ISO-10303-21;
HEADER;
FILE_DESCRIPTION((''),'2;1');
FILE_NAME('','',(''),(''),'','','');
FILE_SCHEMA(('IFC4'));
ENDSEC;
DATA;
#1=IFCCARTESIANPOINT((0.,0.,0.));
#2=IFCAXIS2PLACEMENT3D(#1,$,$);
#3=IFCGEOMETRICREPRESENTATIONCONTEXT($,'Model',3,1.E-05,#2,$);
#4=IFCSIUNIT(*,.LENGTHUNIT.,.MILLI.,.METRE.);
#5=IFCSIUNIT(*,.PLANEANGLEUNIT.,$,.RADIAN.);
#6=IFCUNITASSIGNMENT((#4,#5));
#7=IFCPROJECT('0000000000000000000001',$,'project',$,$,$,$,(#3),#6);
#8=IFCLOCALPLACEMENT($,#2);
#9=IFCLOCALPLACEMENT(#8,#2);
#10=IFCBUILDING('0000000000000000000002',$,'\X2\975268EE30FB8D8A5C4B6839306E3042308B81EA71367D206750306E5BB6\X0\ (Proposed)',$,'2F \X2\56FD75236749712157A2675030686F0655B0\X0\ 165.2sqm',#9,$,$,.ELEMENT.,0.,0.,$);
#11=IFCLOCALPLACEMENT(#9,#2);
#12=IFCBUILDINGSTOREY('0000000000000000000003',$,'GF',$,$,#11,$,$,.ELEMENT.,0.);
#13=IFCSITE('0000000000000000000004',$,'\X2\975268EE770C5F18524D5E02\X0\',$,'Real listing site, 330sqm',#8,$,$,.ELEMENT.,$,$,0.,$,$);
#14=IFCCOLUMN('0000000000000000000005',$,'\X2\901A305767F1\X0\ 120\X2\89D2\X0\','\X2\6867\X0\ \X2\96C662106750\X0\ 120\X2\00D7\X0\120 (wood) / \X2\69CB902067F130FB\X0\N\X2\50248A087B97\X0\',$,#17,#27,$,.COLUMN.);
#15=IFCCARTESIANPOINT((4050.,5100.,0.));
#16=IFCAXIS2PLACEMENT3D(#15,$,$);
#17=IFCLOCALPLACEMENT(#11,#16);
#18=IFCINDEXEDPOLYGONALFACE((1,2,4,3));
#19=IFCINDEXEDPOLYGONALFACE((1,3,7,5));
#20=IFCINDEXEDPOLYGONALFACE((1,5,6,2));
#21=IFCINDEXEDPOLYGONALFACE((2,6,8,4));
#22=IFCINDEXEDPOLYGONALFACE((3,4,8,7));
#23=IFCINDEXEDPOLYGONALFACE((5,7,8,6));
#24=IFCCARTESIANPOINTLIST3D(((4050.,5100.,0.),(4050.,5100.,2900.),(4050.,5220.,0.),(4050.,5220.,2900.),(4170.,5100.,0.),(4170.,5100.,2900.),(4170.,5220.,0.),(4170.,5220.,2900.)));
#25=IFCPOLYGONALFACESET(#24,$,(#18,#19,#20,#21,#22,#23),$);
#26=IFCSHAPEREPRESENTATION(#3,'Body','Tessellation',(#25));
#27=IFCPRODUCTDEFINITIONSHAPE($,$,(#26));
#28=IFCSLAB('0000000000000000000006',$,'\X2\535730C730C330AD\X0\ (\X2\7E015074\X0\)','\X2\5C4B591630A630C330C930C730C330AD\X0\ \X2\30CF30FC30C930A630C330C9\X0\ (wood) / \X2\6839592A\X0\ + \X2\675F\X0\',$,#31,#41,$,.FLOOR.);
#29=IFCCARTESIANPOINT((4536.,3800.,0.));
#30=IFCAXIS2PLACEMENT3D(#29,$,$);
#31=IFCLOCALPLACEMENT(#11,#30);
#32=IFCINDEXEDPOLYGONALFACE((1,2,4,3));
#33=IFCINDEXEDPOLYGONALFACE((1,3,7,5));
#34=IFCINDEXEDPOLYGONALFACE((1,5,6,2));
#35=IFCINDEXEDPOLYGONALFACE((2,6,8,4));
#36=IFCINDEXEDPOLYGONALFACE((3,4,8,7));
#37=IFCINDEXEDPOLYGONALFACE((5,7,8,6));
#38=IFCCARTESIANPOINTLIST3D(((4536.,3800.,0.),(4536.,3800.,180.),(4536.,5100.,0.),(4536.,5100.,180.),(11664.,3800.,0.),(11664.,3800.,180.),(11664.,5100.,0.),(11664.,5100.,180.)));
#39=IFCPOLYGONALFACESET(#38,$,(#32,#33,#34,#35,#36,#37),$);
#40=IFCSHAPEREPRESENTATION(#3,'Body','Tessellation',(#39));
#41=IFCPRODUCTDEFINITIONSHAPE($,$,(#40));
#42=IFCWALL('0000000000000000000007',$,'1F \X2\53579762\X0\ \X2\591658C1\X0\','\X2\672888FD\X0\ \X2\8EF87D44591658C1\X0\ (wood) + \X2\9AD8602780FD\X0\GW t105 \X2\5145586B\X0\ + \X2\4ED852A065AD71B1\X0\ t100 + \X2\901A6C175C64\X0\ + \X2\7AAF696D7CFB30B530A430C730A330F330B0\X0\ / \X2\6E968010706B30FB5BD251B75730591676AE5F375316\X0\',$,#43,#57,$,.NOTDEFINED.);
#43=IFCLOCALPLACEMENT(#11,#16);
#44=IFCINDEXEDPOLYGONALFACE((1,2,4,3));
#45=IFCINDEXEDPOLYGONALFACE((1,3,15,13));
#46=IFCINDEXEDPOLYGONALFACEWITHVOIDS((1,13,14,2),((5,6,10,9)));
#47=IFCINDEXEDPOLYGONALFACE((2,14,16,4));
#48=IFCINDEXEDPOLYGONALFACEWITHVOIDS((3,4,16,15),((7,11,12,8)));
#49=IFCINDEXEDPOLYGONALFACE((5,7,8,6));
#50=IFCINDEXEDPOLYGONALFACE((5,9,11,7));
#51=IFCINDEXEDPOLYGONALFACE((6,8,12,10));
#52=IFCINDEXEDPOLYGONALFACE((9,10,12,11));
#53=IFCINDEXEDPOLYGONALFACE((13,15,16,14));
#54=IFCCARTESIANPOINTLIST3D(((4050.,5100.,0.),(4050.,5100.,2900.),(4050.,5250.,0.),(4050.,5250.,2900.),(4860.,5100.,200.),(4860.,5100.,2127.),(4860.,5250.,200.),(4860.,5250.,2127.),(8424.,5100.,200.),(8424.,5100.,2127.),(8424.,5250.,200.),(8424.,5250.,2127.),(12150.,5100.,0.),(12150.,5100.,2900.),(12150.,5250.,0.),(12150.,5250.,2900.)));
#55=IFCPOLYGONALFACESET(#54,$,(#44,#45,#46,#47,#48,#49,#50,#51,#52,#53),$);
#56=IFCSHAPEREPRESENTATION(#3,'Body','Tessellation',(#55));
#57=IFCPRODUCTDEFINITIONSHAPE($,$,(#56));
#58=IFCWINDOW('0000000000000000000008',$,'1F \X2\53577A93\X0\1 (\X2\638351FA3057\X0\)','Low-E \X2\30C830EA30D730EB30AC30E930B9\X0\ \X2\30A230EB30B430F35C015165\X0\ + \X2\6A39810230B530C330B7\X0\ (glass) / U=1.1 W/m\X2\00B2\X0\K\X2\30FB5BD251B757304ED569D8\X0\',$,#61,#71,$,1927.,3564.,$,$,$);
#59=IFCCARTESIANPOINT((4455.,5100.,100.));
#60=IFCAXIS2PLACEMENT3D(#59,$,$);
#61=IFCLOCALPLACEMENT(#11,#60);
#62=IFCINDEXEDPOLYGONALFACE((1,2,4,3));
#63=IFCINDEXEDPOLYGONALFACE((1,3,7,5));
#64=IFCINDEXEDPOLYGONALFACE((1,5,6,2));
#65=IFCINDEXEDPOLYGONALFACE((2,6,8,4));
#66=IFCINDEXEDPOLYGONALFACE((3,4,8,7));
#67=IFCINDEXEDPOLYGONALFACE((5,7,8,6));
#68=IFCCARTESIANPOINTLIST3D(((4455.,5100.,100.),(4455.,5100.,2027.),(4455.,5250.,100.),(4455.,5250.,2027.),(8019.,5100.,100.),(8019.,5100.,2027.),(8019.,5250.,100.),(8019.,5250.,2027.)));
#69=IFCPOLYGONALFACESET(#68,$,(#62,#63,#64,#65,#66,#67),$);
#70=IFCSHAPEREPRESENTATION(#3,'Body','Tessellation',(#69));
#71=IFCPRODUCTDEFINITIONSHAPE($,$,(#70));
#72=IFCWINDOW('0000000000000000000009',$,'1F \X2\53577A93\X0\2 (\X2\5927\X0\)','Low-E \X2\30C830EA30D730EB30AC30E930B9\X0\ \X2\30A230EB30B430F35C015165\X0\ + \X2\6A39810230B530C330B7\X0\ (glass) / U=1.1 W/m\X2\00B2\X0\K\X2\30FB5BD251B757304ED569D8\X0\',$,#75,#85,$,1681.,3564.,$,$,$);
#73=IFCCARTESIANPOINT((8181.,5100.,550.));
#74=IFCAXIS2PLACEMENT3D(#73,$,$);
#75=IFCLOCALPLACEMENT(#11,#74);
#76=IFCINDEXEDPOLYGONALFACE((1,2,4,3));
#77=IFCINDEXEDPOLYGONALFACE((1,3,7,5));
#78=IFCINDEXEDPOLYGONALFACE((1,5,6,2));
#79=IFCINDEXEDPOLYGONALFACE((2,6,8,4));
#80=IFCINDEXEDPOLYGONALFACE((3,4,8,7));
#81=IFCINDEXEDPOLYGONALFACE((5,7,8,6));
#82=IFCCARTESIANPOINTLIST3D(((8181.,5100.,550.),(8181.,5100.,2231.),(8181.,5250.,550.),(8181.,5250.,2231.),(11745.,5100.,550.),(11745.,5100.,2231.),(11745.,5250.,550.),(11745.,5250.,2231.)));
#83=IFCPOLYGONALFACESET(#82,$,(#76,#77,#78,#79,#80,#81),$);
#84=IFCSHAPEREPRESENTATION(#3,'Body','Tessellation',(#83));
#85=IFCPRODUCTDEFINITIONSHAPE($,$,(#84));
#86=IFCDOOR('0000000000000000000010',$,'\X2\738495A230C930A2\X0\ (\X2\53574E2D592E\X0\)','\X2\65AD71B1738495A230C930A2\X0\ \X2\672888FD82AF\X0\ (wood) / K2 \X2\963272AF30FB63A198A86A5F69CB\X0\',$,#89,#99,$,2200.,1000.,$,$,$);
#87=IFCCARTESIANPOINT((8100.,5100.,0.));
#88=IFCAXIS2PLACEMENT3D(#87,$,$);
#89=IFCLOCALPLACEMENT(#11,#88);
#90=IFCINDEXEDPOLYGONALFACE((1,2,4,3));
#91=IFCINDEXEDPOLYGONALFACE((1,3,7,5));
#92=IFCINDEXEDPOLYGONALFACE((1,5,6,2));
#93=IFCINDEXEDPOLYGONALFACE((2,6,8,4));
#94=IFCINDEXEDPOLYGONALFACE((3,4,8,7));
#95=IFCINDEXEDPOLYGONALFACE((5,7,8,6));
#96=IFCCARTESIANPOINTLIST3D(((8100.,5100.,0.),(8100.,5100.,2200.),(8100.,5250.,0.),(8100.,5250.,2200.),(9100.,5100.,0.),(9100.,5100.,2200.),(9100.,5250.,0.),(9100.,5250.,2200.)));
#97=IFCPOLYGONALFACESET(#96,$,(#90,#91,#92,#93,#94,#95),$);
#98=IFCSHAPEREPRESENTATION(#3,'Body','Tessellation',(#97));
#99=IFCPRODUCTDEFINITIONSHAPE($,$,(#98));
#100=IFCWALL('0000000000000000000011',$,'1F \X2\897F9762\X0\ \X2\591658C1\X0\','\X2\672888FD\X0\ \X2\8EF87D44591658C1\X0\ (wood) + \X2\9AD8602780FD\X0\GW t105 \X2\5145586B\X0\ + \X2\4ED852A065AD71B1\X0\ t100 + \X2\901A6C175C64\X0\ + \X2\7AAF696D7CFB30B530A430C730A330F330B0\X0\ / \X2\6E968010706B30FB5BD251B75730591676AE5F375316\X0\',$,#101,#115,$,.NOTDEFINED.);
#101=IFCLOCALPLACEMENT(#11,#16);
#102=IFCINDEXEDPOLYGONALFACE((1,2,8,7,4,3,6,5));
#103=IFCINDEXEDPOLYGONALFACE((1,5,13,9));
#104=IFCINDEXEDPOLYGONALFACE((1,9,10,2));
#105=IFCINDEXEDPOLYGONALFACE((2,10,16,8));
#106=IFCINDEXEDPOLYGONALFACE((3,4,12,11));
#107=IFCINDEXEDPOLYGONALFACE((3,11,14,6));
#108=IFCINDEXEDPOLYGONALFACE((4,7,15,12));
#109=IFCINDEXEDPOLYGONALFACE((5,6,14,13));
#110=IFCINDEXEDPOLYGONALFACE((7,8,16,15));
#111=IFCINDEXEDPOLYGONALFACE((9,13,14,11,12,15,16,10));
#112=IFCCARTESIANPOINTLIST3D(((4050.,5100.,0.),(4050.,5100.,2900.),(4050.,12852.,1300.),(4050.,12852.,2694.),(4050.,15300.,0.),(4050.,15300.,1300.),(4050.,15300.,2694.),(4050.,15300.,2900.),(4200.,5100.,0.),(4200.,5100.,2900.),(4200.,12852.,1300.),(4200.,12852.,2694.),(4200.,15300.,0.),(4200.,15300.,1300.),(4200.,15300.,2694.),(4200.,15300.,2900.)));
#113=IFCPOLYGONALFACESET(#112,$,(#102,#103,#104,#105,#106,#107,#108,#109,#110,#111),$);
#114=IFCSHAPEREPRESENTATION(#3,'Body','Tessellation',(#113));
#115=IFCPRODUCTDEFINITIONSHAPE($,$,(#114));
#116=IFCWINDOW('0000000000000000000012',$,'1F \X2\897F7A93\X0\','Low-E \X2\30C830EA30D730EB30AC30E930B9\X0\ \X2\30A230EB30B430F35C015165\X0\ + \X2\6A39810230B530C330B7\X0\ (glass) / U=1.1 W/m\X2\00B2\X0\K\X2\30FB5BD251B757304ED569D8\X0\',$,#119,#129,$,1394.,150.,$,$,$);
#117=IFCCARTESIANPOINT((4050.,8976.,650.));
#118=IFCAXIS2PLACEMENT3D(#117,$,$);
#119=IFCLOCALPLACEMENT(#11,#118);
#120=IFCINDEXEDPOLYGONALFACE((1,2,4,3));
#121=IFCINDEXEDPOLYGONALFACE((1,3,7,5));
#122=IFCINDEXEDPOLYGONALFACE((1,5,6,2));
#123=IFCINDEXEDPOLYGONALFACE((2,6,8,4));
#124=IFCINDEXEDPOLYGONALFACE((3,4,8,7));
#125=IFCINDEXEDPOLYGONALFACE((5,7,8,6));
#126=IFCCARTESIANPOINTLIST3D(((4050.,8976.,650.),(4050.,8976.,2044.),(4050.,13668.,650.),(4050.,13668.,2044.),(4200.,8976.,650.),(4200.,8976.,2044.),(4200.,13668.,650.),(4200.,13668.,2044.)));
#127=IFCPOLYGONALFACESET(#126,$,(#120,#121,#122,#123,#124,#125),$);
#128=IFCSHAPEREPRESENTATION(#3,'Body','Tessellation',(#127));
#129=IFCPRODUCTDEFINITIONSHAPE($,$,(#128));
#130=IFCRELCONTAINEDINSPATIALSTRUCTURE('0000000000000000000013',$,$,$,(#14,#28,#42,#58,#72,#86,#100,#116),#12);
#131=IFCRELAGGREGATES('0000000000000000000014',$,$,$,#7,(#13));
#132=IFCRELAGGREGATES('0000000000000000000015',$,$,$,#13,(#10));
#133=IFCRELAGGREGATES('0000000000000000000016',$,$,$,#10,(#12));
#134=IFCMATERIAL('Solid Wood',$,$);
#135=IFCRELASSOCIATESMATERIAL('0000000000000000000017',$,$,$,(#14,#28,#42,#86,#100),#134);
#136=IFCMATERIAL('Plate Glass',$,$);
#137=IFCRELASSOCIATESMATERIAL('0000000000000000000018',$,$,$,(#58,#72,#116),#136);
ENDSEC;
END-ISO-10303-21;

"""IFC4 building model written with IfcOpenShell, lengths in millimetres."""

from ifc_helpers import new_model, si_unit, frame, frame_2d, origin, place, context, project, spatial, rectangle, extrude, material, element, fill, save


model = new_model("IFC4")

# Units and contexts
model_context = context("Model", 3, precision=1e-05, world=origin())
ifc_project = project(units=[si_unit("LENGTHUNIT", "METRE", prefix="MILLI"), si_unit("PLANEANGLEUNIT", "RADIAN")], contexts=[model_context])

# Site, building, storey
site_placement = place(None, origin())
site = spatial("IfcSite", under=ifc_project, at=site_placement, Name="青森県弘前市", ObjectType="Real listing site, 330sqm", CompositionType="ELEMENT", RefElevation=0.0)
building_placement = place(site_placement, origin())
building = spatial("IfcBuilding", under=site, at=building_placement, Name="青森・越屋根のある自然素材の家 (Proposed)", ObjectType="2F 国産杉無垢材と漆喰 165.2sqm", CompositionType="ELEMENT", ElevationOfRefHeight=0.0, ElevationOfTerrain=0.0)
storey_placement = place(building_placement, origin())
storey = spatial("IfcBuildingStorey", under=building, at=storey_placement, Name="GF", CompositionType="ELEMENT", Elevation=0.0)

# Column
ifc_material_1 = material(Name="Solid Wood")
column_placement = place(storey_placement, frame((4050.0, 5100.0, 0.0)))
element("IfcColumn", 1, at=column_placement, inside=storey, material=ifc_material_1, Name="通し柱 120角", Description="桧 集成材 120×120 (wood) / 構造柱・N値計算", PredefinedType="COLUMN", context=model_context, shape_type="SweptSolid", body=[
    extrude(rectangle(XDim=120.0, YDim=120.0, at=frame_2d((60.0, 60.0))), frame((4050.0, 5100.0, 0.0)), (0.0, 0.0, 1.0), 2900.0),
])

# Slab
slab_1_placement = place(storey_placement, frame((4536.0, 3800.0, 0.0)))
element("IfcSlab", 2, at=slab_1_placement, inside=storey, material=ifc_material_1, Name="南デッキ (縁側)", Description="屋外ウッドデッキ ハードウッド (wood) / 根太 + 束", PredefinedType="FLOOR", context=model_context, shape_type="SweptSolid", body=[
    extrude(rectangle(XDim=7128.0, YDim=1300.0, at=frame_2d((3564.0, 650.0))), frame((4536.0, 3800.0, 0.0)), (0.0, 0.0, 1.0), 180.0),
])

# Wall, openings, windows, door
wall_1_placement = place(storey_placement, frame((4050.0, 5100.0, 0.0)))
wall_1 = element("IfcWall", 3, at=wall_1_placement, inside=storey, material=ifc_material_1, Name="1F 南面 外壁", Description="木製 軸組外壁 (wood) + 高性能GW t105 充填 + 付加断熱 t100 + 通気層 + 窯業系サイディング / 準耐火・寒冷地外皮強化", PredefinedType="NOTDEFINED", context=model_context, shape_type="SweptSolid", body=[
    extrude(rectangle(XDim=8100.0, YDim=150.0, at=frame_2d((4050.0, 75.0))), frame((4050.0, 5100.0, 0.0)), (0.0, 0.0, 1.0), 2900.0),
])
opening_1_placement = place(storey_placement, frame((4455.0, 5100.0, 100.0)))
opening_1 = element("IfcOpeningElement", 4, at=opening_1_placement, cuts=wall_1, PredefinedType="NOTDEFINED", context=model_context, shape_type="SweptSolid", body=[
    extrude(rectangle(XDim=3564.0, YDim=150.0, at=frame_2d((1782.0, 75.0))), frame((4455.0, 5100.0, 100.0)), (0.0, 0.0, 1.0), 1927.0),
])
opening_2_placement = place(storey_placement, frame((8181.0, 5100.0, 550.0)))
opening_2 = element("IfcOpeningElement", 5, at=opening_2_placement, cuts=wall_1, PredefinedType="NOTDEFINED", context=model_context, shape_type="SweptSolid", body=[
    extrude(rectangle(XDim=3564.0, YDim=150.0, at=frame_2d((1782.0, 75.0))), frame((8181.0, 5100.0, 550.0)), (0.0, 0.0, 1.0), 1681.0),
])
opening_3_placement = place(storey_placement, frame((8100.0, 5100.0, 0.0)))
opening_3 = element("IfcOpeningElement", 6, at=opening_3_placement, cuts=wall_1, PredefinedType="NOTDEFINED", context=model_context, shape_type="SweptSolid", body=[
    extrude(rectangle(XDim=1000.0, YDim=150.0, at=frame_2d((500.0, 75.0))), frame((8100.0, 5100.0, 0.0)), (0.0, 0.0, 1.0), 2200.0),
])
ifc_material_2 = material(Name="Plate Glass")
window_1_placement = place(storey_placement, frame((4455.0, 5100.0, 100.0)))
window_1 = element("IfcWindow", 7, at=window_1_placement, inside=storey, material=ifc_material_2, Name="1F 南窓1 (掃出し)", Description="Low-E トリプルガラス アルゴン封入 + 樹脂サッシ (glass) / U=1.1 W/m²K・寒冷地仕様", OverallHeight=1927.0, OverallWidth=3564.0, context=model_context, shape_type="SweptSolid", body=[
    extrude(rectangle(XDim=3564.0, YDim=150.0, at=frame_2d((1782.0, 75.0))), frame((4455.0, 5100.0, 100.0)), (0.0, 0.0, 1.0), 1927.0),
])
fill(opening_1, window_1)
window_2_placement = place(storey_placement, frame((8181.0, 5100.0, 550.0)))
window_2 = element("IfcWindow", 8, at=window_2_placement, inside=storey, material=ifc_material_2, Name="1F 南窓2 (大)", Description="Low-E トリプルガラス アルゴン封入 + 樹脂サッシ (glass) / U=1.1 W/m²K・寒冷地仕様", OverallHeight=1681.0, OverallWidth=3564.0, context=model_context, shape_type="SweptSolid", body=[
    extrude(rectangle(XDim=3564.0, YDim=150.0, at=frame_2d((1782.0, 75.0))), frame((8181.0, 5100.0, 550.0)), (0.0, 0.0, 1.0), 1681.0),
])
fill(opening_2, window_2)
door_placement = place(storey_placement, frame((8100.0, 5100.0, 0.0)))
door = element("IfcDoor", 9, at=door_placement, inside=storey, material=ifc_material_1, Name="玄関ドア (南中央)", Description="断熱玄関ドア 木製芯 (wood) / K2 防犯・採風機構", OverallHeight=2200.0, OverallWidth=1000.0, context=model_context, shape_type="SweptSolid", body=[
    extrude(rectangle(XDim=1000.0, YDim=150.0, at=frame_2d((500.0, 75.0))), frame((8100.0, 5100.0, 0.0)), (0.0, 0.0, 1.0), 2200.0),
])
fill(opening_3, door)

# Wall, opening, window
wall_2_placement = place(storey_placement, frame((4050.0, 5100.0, 0.0)))
wall_2 = element("IfcWall", 10, at=wall_2_placement, inside=storey, material=ifc_material_1, Name="1F 西面 外壁", Description="木製 軸組外壁 (wood) + 高性能GW t105 充填 + 付加断熱 t100 + 通気層 + 窯業系サイディング / 準耐火・寒冷地外皮強化", PredefinedType="NOTDEFINED", context=model_context, shape_type="SweptSolid", body=[
    extrude(rectangle(XDim=150.0, YDim=10200.0, at=frame_2d((75.0, 5100.0))), frame((4050.0, 5100.0, 0.0)), (0.0, 0.0, 1.0), 2900.0),
])
opening_4_placement = place(storey_placement, frame((4050.0, 8976.0, 650.0)))
opening_4 = element("IfcOpeningElement", 11, at=opening_4_placement, cuts=wall_2, PredefinedType="NOTDEFINED", context=model_context, shape_type="SweptSolid", body=[
    extrude(rectangle(XDim=150.0, YDim=4692.0, at=frame_2d((75.0, 2346.0))), frame((4050.0, 8976.0, 650.0)), (0.0, 0.0, 1.0), 1394.0),
])
window_3_placement = place(storey_placement, frame((4050.0, 8976.0, 650.0)))
window_3 = element("IfcWindow", 12, at=window_3_placement, inside=storey, material=ifc_material_2, Name="1F 西窓", Description="Low-E トリプルガラス アルゴン封入 + 樹脂サッシ (glass) / U=1.1 W/m²K・寒冷地仕様", OverallHeight=1394.0, OverallWidth=150.0, context=model_context, shape_type="SweptSolid", body=[
    extrude(rectangle(XDim=150.0, YDim=4692.0, at=frame_2d((75.0, 2346.0))), frame((4050.0, 8976.0, 650.0)), (0.0, 0.0, 1.0), 1394.0),
])
fill(opening_4, window_3)

save(model, "model.ifc")
